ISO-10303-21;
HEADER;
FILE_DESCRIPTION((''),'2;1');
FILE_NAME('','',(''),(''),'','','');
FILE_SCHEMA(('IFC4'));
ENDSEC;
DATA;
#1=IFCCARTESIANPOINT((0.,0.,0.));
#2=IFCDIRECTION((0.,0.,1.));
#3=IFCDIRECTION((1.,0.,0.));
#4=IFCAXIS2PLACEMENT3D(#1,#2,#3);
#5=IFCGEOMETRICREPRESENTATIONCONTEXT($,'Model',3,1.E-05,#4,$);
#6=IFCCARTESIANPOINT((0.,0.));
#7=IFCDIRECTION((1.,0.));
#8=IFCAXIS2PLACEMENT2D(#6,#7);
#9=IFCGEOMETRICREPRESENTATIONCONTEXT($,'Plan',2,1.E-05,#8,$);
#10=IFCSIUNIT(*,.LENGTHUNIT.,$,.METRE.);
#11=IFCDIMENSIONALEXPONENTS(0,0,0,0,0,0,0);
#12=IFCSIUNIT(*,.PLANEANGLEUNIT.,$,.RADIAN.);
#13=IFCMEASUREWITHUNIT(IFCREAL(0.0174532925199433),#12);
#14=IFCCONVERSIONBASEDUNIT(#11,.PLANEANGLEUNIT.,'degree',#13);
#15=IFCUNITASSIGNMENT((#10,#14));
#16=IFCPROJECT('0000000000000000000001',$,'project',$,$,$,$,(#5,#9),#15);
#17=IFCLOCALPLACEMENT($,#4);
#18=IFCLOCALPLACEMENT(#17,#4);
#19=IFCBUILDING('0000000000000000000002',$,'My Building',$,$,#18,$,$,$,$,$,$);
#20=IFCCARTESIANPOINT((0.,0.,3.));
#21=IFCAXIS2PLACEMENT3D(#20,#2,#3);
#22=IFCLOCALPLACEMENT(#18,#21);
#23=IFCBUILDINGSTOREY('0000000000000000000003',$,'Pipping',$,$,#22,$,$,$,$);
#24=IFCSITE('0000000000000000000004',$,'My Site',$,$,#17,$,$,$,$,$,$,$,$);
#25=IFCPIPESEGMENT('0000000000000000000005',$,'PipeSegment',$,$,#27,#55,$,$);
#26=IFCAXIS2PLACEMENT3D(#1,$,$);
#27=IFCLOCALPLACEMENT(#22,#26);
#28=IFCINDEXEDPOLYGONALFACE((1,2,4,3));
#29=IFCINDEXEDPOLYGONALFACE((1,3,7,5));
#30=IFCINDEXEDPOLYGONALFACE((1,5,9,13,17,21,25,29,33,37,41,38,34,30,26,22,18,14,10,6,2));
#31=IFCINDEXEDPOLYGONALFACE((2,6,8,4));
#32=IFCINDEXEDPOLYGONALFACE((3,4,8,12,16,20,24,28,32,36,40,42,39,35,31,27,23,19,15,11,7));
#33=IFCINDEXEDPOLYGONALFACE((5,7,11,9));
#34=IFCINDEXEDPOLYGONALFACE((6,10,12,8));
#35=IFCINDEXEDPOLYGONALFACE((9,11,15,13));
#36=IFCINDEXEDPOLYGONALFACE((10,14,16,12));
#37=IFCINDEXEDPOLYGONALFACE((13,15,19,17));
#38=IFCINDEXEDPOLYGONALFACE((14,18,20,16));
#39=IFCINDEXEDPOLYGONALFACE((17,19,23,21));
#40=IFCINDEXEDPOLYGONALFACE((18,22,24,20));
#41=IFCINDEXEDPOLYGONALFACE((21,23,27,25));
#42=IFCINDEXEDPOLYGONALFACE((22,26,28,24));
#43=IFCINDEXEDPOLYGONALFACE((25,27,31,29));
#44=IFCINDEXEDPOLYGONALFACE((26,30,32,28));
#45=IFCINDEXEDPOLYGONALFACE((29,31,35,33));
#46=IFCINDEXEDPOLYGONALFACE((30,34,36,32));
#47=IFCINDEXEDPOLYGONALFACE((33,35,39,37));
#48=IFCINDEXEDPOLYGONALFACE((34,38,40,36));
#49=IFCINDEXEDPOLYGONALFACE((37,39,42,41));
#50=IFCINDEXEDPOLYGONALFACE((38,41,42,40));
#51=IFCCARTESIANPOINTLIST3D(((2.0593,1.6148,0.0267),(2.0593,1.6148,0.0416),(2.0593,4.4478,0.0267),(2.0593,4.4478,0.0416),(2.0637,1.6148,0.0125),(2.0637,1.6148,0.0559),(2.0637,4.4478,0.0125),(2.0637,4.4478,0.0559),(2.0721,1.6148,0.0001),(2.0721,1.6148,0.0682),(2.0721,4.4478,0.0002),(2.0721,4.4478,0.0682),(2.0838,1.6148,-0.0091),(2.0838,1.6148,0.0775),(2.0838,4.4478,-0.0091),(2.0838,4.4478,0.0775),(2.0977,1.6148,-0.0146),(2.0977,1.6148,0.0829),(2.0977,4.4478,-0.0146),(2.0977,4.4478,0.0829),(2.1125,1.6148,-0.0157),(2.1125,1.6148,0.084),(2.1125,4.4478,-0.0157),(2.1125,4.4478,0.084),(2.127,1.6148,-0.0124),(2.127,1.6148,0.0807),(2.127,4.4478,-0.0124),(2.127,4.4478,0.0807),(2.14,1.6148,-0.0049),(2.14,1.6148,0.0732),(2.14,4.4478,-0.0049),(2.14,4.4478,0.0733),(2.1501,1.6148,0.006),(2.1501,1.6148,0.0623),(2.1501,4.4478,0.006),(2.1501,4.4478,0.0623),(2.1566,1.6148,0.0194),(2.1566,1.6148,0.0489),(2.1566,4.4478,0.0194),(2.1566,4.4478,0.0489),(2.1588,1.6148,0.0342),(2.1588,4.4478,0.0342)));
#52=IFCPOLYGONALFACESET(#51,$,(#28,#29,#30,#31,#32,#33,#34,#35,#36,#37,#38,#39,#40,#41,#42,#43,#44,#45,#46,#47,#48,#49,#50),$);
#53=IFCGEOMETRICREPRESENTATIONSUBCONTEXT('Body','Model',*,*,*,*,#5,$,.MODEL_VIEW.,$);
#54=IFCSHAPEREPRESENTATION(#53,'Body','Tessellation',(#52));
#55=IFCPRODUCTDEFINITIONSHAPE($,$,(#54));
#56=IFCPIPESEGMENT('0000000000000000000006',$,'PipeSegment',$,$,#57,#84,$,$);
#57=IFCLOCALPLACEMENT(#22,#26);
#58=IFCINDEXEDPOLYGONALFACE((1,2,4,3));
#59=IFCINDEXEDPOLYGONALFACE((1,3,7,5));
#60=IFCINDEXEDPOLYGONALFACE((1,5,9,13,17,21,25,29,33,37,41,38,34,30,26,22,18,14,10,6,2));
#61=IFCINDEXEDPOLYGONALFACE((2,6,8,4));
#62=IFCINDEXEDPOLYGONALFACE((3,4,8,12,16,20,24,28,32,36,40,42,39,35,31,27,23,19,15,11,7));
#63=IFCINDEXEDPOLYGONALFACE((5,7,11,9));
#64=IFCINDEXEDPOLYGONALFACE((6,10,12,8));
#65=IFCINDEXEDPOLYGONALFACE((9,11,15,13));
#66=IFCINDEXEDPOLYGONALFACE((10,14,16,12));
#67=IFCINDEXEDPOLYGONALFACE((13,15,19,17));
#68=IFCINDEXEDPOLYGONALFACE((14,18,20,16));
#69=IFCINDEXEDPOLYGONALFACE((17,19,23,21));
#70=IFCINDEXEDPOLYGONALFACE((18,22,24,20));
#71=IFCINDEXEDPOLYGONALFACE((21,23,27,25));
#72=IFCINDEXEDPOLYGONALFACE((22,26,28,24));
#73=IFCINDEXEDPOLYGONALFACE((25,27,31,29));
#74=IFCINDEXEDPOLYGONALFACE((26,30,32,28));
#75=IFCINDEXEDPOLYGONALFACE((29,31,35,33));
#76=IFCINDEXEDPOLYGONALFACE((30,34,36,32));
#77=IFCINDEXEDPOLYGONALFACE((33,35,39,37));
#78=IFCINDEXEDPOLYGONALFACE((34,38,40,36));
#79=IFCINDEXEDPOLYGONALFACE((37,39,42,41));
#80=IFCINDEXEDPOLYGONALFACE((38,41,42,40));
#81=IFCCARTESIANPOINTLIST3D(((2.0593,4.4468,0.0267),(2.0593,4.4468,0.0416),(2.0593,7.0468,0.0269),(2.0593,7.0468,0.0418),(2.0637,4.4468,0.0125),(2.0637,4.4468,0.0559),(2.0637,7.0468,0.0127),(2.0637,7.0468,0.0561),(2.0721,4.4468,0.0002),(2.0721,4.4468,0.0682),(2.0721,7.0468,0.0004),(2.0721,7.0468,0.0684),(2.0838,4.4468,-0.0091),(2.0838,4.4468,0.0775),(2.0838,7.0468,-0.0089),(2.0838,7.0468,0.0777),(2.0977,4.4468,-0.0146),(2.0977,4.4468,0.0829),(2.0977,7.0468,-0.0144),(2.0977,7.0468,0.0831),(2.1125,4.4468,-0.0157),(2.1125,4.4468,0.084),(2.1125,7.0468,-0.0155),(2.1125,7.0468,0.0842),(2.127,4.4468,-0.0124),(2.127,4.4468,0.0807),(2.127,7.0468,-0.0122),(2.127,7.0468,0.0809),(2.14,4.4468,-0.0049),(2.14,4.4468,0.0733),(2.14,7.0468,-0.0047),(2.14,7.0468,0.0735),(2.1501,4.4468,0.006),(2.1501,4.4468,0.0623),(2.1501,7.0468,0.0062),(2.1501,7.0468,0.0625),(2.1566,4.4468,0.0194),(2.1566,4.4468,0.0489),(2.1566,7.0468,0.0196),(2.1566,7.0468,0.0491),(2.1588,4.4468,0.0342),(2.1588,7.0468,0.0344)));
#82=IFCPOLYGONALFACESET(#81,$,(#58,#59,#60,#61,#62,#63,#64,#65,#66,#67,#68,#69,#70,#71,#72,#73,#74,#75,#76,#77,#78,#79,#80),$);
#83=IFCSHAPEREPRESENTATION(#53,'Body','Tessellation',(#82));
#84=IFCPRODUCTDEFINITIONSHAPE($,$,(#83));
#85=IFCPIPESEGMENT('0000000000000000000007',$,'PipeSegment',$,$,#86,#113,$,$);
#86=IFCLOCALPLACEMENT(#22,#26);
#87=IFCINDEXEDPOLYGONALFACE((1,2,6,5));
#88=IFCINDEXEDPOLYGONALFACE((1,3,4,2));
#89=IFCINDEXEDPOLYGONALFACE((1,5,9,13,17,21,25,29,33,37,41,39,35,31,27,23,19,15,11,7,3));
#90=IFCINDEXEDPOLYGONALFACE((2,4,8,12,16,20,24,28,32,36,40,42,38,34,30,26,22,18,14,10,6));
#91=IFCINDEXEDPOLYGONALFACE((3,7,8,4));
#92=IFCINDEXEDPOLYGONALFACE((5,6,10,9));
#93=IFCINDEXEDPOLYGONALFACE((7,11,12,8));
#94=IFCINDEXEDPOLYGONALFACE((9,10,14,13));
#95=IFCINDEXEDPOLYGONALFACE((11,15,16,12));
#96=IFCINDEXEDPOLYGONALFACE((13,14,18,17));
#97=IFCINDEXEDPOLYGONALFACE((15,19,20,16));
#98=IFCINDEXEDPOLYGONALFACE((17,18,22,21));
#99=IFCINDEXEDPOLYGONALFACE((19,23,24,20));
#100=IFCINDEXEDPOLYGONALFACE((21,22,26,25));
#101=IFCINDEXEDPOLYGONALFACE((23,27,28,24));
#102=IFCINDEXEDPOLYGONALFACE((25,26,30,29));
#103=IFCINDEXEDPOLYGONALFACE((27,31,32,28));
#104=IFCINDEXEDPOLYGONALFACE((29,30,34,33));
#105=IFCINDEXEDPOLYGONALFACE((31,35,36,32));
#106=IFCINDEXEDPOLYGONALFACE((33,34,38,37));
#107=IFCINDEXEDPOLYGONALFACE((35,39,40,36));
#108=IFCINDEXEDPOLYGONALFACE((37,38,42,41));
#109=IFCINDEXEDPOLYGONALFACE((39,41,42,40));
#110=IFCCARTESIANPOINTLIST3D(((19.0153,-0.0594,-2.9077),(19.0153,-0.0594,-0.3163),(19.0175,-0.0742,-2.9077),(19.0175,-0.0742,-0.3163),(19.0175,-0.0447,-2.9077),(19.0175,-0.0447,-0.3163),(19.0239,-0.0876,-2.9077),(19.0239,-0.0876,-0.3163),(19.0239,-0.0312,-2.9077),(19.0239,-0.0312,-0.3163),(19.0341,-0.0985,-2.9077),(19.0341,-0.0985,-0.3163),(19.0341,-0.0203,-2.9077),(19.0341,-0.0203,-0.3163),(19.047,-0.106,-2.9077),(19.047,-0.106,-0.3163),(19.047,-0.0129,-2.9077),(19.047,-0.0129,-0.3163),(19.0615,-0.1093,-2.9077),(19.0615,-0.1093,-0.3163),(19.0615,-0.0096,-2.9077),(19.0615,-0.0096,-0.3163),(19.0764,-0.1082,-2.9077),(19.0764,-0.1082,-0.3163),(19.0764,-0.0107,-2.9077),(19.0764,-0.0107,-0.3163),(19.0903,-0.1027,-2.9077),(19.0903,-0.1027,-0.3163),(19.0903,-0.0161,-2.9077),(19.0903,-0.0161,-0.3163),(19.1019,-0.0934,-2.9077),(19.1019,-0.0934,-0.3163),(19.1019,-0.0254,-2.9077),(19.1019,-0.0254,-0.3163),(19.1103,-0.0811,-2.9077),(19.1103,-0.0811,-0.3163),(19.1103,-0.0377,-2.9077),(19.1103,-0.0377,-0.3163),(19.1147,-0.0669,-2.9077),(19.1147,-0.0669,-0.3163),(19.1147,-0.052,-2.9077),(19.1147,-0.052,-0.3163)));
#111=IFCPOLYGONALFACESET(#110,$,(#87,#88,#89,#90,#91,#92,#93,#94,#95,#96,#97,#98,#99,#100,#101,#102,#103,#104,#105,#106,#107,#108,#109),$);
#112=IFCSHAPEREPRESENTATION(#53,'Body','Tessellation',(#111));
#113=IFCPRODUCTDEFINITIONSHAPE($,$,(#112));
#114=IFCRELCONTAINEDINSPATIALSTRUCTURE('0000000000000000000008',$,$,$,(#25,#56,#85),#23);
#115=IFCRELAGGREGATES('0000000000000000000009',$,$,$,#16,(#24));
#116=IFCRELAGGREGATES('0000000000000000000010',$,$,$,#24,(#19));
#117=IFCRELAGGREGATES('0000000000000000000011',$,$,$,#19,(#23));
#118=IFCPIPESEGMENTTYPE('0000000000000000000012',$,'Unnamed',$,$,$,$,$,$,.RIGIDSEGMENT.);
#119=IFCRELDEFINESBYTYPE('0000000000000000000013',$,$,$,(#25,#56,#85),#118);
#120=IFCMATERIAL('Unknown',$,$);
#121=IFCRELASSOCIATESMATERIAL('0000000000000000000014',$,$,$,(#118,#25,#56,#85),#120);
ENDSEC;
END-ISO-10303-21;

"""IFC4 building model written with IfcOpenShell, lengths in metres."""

from ifc_helpers import new_model, entity, si_unit, converted_unit, frame, origin_with_axes, origin_2d_with_axis, place, context, subcontext, project, spatial, circle, extrude, material, material_profile, profile_set, profile_usage, type_object, element, save


model = new_model("IFC4")

# Units and contexts
model_context = context("Model", 3, precision=1e-05, world=origin_with_axes())
plan_context = context("Plan", 2, precision=1e-05, world=origin_2d_with_axis())
body_context = subcontext(model_context, "Body", "Model", "MODEL_VIEW")
ifc_project = project(units=[si_unit("LENGTHUNIT", "METRE"), converted_unit("PLANEANGLEUNIT", "degree", entity("IfcReal", 0.0174532925199433), si_unit("PLANEANGLEUNIT", "RADIAN"), dimensions=[0, 0, 0, 0, 0, 0, 0])], contexts=[model_context, plan_context])

# Site, building, storey
site_placement = place(None, origin_with_axes())
site = spatial("IfcSite", under=ifc_project, at=site_placement, Name="My Site")
building_placement = place(site_placement, origin_with_axes())
building = spatial("IfcBuilding", under=site, at=building_placement, Name="My Building")
storey_placement = place(building_placement, frame((0.0, 0.0, 3.0), z_axis=(0.0, 0.0, 1.0), x_axis=(1.0, 0.0, 0.0)))
storey = spatial("IfcBuildingStorey", under=building, at=storey_placement, Name="Pipping")

# Pipe segments
ifc_material = material(Name="Unknown")
ifc_material_profile_1 = material_profile(ifc_material, circle(Radius=0.05))
ifc_profile_set_1 = profile_set([ifc_material_profile_1])
pipe_segment_type = type_object("IfcPipeSegmentType", Name="Unnamed", PredefinedType="RIGIDSEGMENT", material=ifc_profile_set_1)
ifc_profile_usage_1 = profile_usage(ifc_profile_set_1, cardinal=5)
pipe_segment_1_placement = place(storey_placement, frame((2.1088, 4.4478, 0.0342), z_axis=(0.0, -1.0, -0.000004), x_axis=(1.0, 0.0, 0.0)))
element("IfcPipeSegment", 1, at=pipe_segment_1_placement, inside=storey, type_object=pipe_segment_type, material=ifc_profile_usage_1, Name="PipeSegment", context=body_context, shape_type="SweptSolid", body=[
    extrude(circle(Radius=0.05), origin_with_axes(), (0.0, 0.0, 1.0), 2.8329),
])
ifc_profile_usage_2 = profile_usage(ifc_profile_set_1, cardinal=5)
pipe_segment_2_placement = place(storey_placement, frame((2.1088, 4.4468, 0.0342), z_axis=(0.0, 1.0, 0.000073), x_axis=(1.0, 0.0, 0.0)))
element("IfcPipeSegment", 2, at=pipe_segment_2_placement, inside=storey, type_object=pipe_segment_type, material=ifc_profile_usage_2, Name="PipeSegment", context=body_context, shape_type="SweptSolid", body=[
    extrude(circle(Radius=0.05), origin_with_axes(), (0.0, 0.0, 1.0), 2.6),
])
ifc_profile_usage_3 = profile_usage(ifc_profile_set_1, cardinal=5)
pipe_segment_3_placement = place(storey_placement, frame((19.0653, -0.0594, -0.3163), z_axis=(0.0, 0.0, -1.0), x_axis=(-1.0, 0.0, 0.0)))
element("IfcPipeSegment", 3, at=pipe_segment_3_placement, inside=storey, type_object=pipe_segment_type, material=ifc_profile_usage_3, Name="PipeSegment", context=body_context, shape_type="SweptSolid", body=[
    extrude(circle(Radius=0.05), origin_with_axes(), (0.0, 0.0, 1.0), 2.5914),
])

save(model, "model.ifc")
